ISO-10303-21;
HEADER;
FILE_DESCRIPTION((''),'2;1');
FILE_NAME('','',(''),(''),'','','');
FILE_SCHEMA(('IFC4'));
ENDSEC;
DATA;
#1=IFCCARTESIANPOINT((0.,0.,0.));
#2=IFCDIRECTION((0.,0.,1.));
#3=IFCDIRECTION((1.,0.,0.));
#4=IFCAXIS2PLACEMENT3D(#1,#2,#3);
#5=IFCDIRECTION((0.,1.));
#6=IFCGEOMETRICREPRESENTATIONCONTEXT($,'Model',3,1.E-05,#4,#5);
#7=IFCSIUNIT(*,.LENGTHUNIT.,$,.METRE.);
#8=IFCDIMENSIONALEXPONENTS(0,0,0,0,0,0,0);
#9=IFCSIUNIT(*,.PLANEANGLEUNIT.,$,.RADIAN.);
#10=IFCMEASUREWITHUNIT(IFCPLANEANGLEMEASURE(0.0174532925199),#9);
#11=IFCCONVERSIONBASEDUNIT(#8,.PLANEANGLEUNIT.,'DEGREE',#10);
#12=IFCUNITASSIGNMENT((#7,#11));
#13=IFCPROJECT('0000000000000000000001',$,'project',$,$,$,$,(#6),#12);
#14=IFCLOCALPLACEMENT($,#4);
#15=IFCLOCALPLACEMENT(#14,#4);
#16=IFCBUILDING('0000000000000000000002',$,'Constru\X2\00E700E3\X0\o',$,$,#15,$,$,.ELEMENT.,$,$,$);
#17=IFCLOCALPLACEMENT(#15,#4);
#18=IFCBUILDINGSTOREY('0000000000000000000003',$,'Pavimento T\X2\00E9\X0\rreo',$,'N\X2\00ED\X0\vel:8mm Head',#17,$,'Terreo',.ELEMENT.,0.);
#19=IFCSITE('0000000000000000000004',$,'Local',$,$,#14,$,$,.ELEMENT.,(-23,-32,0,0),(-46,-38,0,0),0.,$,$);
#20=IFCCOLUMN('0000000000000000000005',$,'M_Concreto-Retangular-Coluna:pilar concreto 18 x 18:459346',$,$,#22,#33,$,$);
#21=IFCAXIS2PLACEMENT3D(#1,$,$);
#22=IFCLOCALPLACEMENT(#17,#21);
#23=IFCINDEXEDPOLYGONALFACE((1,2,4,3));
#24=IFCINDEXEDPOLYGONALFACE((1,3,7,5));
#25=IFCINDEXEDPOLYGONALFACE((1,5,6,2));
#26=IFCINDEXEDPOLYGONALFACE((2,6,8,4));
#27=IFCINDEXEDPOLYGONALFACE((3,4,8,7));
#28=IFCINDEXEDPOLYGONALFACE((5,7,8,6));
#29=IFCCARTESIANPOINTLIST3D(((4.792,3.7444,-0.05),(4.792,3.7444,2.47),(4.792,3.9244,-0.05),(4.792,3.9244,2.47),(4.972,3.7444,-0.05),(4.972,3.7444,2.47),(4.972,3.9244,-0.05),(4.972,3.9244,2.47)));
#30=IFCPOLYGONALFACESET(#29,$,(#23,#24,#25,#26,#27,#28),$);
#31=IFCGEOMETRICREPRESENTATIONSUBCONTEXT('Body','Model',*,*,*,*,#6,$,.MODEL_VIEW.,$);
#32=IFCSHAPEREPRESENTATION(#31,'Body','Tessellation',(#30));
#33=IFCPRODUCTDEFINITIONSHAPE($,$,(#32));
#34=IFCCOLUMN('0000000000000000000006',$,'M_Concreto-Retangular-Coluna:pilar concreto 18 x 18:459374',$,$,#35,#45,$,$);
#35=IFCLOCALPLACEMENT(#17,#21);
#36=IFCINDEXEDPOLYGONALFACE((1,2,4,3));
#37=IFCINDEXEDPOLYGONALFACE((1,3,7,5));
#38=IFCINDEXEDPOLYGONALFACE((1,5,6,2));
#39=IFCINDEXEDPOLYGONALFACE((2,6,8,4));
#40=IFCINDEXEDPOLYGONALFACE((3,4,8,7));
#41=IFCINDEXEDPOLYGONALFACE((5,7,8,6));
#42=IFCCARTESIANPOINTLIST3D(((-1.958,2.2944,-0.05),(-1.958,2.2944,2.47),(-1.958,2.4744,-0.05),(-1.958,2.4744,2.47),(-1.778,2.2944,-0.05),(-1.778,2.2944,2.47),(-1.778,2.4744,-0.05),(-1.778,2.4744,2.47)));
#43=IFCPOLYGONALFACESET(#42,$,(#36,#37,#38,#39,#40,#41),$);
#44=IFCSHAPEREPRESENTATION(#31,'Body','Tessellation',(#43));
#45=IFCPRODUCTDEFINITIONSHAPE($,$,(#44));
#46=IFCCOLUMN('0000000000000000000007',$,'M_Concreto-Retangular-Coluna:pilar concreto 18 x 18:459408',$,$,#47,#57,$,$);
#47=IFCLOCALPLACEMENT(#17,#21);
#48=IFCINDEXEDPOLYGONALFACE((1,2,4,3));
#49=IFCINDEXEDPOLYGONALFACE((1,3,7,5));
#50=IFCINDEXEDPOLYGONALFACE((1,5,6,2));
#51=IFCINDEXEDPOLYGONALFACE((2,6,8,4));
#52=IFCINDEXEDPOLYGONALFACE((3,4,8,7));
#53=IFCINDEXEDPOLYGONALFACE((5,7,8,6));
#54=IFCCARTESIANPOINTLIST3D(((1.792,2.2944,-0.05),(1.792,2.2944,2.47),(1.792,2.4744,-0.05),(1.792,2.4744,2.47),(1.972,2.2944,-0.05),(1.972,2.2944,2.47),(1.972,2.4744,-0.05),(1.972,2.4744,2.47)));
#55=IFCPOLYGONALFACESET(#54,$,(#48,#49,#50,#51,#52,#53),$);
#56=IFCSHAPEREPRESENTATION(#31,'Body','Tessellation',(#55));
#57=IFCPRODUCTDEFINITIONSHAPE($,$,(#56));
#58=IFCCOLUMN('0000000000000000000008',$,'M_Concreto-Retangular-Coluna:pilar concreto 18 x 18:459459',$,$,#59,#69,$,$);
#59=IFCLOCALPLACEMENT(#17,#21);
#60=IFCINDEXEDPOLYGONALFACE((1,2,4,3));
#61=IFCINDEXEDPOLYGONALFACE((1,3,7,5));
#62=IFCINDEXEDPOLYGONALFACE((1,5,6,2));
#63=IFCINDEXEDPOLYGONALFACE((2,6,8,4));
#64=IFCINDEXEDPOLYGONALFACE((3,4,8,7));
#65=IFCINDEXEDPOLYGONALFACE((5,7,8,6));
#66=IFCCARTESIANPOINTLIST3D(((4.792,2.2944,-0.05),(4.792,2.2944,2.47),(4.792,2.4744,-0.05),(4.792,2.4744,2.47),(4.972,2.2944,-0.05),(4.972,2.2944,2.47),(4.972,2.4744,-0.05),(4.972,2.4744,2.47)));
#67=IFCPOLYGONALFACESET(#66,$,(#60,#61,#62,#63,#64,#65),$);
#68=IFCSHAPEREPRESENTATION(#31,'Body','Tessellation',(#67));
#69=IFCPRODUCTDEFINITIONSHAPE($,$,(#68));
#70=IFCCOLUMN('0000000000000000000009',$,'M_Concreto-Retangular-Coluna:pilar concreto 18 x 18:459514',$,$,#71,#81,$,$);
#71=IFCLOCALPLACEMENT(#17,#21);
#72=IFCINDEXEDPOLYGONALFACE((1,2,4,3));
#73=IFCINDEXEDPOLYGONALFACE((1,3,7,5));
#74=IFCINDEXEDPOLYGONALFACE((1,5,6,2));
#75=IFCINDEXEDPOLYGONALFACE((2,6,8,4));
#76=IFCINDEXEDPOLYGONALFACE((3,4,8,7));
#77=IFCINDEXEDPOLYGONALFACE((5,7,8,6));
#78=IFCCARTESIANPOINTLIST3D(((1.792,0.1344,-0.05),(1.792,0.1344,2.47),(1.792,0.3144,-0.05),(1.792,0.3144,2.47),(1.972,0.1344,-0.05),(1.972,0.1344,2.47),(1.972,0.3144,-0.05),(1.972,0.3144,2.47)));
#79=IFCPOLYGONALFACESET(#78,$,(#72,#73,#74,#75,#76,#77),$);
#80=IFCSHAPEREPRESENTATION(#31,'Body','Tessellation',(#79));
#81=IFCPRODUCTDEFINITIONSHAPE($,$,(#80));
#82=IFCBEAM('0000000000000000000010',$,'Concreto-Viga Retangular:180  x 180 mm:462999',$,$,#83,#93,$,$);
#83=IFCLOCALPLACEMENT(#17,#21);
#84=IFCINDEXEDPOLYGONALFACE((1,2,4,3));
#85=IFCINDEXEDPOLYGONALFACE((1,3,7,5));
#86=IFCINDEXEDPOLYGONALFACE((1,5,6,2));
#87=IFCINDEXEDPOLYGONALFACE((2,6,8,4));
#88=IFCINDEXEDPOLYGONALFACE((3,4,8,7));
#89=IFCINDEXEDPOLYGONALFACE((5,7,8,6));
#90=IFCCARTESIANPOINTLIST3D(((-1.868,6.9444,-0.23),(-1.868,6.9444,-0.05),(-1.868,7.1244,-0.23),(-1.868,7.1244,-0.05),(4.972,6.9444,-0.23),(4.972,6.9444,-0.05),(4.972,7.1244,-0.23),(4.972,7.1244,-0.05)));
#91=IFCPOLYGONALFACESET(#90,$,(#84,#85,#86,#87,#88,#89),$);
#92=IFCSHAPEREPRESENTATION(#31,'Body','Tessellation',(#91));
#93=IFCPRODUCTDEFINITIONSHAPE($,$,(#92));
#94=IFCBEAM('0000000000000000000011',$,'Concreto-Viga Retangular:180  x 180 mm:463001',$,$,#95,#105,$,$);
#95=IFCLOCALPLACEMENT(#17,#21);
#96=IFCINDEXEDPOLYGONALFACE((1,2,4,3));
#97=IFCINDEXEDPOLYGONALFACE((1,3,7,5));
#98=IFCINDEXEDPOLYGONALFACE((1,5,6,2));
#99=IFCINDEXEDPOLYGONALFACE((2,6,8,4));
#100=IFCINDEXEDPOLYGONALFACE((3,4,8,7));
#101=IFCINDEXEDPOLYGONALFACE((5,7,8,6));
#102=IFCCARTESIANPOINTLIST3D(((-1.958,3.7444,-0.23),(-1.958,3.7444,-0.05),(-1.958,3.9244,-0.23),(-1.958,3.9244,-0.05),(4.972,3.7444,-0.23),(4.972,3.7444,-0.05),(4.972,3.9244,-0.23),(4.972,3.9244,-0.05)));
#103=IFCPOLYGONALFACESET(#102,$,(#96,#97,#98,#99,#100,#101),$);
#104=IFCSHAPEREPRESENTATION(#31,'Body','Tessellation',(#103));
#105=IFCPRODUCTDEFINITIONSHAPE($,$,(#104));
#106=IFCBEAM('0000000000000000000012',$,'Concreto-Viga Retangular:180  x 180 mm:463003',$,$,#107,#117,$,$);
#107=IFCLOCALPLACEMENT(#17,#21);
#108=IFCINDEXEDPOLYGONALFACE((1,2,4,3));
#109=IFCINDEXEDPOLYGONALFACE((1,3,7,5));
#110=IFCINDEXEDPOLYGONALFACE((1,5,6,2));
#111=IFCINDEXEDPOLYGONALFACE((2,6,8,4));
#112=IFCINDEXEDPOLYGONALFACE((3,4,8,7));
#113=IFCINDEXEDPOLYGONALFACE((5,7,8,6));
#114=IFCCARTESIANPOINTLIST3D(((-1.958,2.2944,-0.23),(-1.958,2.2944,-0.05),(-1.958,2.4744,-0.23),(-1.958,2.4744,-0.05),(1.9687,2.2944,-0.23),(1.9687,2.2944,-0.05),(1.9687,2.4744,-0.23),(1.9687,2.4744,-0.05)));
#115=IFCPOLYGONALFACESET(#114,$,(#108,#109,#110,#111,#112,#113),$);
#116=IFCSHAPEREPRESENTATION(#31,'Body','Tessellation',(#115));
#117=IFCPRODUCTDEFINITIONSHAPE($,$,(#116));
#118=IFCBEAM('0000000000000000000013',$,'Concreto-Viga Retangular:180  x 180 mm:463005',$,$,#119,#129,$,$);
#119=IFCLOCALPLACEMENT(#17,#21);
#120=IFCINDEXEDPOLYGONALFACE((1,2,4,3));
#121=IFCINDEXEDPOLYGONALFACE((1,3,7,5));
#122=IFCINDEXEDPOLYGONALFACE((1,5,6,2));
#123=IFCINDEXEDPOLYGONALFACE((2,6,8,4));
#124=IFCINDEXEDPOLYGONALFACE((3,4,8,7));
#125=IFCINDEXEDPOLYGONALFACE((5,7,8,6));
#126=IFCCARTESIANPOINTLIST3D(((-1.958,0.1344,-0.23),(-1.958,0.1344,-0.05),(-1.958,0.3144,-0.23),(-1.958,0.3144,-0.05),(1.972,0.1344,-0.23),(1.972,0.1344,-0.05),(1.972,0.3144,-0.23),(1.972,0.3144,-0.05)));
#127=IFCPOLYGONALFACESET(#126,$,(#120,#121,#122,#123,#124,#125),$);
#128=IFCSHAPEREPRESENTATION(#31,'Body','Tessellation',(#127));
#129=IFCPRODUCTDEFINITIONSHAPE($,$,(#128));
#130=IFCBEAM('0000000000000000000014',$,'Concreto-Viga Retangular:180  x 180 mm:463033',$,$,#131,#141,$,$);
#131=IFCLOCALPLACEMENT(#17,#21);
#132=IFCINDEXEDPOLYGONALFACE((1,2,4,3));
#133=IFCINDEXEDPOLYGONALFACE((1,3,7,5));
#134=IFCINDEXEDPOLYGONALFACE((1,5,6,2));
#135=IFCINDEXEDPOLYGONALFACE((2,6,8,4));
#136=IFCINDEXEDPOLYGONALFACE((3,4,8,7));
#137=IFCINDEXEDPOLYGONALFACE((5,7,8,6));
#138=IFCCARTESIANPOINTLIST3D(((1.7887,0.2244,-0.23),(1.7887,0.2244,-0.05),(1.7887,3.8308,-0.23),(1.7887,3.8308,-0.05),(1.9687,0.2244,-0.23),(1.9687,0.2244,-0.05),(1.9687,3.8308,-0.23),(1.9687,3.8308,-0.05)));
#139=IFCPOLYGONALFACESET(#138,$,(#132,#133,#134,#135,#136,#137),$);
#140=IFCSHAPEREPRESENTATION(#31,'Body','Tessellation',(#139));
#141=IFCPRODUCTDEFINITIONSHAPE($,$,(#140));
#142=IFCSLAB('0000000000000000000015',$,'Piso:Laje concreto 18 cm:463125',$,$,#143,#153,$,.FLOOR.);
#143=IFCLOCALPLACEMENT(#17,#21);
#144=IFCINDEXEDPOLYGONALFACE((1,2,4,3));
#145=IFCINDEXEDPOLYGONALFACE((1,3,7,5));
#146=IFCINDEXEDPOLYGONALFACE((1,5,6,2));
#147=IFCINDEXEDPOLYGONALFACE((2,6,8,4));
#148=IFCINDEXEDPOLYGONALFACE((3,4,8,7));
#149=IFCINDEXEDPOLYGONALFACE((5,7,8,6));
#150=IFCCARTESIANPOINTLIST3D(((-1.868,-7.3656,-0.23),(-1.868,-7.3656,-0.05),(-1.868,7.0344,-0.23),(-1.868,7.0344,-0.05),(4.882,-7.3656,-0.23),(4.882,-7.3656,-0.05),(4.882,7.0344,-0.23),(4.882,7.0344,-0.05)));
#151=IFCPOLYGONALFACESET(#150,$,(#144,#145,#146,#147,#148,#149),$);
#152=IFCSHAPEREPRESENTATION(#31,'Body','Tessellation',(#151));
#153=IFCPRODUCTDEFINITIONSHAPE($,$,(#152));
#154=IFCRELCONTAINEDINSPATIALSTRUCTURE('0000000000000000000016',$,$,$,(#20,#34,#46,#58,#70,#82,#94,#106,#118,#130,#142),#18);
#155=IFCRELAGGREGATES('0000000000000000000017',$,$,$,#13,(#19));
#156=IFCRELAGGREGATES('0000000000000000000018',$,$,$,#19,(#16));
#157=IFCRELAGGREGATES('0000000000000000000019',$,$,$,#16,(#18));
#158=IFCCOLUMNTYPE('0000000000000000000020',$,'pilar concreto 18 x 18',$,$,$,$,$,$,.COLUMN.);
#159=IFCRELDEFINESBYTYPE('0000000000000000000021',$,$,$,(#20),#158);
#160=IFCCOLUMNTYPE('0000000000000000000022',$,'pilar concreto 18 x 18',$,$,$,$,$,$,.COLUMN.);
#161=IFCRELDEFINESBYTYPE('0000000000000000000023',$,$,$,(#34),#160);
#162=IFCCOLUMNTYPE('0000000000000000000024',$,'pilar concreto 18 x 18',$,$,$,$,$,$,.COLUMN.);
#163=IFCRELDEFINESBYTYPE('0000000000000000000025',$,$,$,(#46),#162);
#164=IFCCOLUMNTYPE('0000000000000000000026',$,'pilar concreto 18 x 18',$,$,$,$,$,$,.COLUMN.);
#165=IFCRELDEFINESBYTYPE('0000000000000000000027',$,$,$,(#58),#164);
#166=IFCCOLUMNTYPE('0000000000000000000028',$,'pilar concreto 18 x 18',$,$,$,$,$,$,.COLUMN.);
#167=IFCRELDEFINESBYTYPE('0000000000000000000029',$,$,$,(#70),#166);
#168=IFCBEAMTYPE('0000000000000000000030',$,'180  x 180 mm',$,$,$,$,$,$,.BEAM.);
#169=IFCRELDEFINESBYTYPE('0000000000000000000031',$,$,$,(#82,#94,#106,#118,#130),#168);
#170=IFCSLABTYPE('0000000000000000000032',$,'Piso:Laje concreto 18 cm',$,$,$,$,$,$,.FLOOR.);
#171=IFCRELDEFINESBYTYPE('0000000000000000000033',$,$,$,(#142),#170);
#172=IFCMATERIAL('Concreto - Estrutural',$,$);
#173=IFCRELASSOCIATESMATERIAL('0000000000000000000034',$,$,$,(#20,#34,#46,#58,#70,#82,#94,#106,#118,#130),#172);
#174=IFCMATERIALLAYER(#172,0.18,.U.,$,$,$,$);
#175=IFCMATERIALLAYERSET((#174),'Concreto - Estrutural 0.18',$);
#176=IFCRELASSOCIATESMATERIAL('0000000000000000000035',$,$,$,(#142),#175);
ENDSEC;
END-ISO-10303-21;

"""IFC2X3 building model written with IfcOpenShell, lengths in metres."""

from ifc_helpers import new_model, entity, si_unit, converted_unit, direction, frame, frame_2d, origin_with_axes, origin_2d_with_axis, place, context, subcontext, project, spatial, polyline, rectangle, outline, extrude, material, layer, layer_set, layer_usage, type_object, element, save


model = new_model("IFC2X3")

# Units and contexts
model_context = context("Model", 3, precision=1e-05, world=origin_with_axes(), true_north=direction((0.0, 1.0)))
body_context = subcontext(model_context, "Body", "Model", "MODEL_VIEW")
ifc_project = project(units=[si_unit("LENGTHUNIT", "METRE"), converted_unit("PLANEANGLEUNIT", "DEGREE", entity("IfcPlaneAngleMeasure", 0.0174532925199), si_unit("PLANEANGLEUNIT", "RADIAN"), dimensions=[0, 0, 0, 0, 0, 0, 0])], contexts=[model_context])

# Site, building, storey
site_placement = place(None, origin_with_axes())
site = spatial("IfcSite", under=ifc_project, at=site_placement, Name="Local", CompositionType="ELEMENT", RefLatitude=(-23, -32, 0, 0), RefLongitude=(-46, -38, 0, 0), RefElevation=0.0)
building_placement = place(site_placement, origin_with_axes())
building = spatial("IfcBuilding", under=site, at=building_placement, Name="Construção", CompositionType="ELEMENT")
storey_placement = place(building_placement, origin_with_axes())
storey = spatial("IfcBuildingStorey", under=building, at=storey_placement, Name="Pavimento Térreo", ObjectType="Nível:8mm Head", LongName="Terreo", CompositionType="ELEMENT", Elevation=0.0)

# Shared definitions
ifc_material = material(Name="Concreto - Estrutural")

# Columns
column_type_1 = type_object("IfcColumnType", Name="pilar concreto 18 x 18", PredefinedType="COLUMN")
column_1_placement = place(storey_placement, frame((4.882, 3.8344, -0.05), z_axis=(0.0, 0.0, 1.0), x_axis=(0.0, -1.0, 0.0)))
element("IfcColumn", 1, at=column_1_placement, inside=storey, type_object=column_type_1, material=ifc_material, Name="M_Concreto-Retangular-Coluna:pilar concreto 18 x 18:459346", context=body_context, shape_type="SweptSolid", body=[
    extrude(rectangle(XDim=0.18, YDim=0.18, at=origin_2d_with_axis()), origin_with_axes(), (0.0, 0.0, 1.0), 2.52),
])
column_type_2 = type_object("IfcColumnType", Name="pilar concreto 18 x 18", PredefinedType="COLUMN")
column_2_placement = place(storey_placement, frame((-1.868, 2.3844, -0.05), z_axis=(0.0, 0.0, 1.0), x_axis=(0.0, -1.0, 0.0)))
element("IfcColumn", 2, at=column_2_placement, inside=storey, type_object=column_type_2, material=ifc_material, Name="M_Concreto-Retangular-Coluna:pilar concreto 18 x 18:459374", context=body_context, shape_type="SweptSolid", body=[
    extrude(rectangle(XDim=0.18, YDim=0.18, at=origin_2d_with_axis()), origin_with_axes(), (0.0, 0.0, 1.0), 2.52),
])
column_type_3 = type_object("IfcColumnType", Name="pilar concreto 18 x 18", PredefinedType="COLUMN")
column_3_placement = place(storey_placement, frame((1.882, 2.3844, -0.05), z_axis=(0.0, 0.0, 1.0), x_axis=(0.0, -1.0, 0.0)))
element("IfcColumn", 3, at=column_3_placement, inside=storey, type_object=column_type_3, material=ifc_material, Name="M_Concreto-Retangular-Coluna:pilar concreto 18 x 18:459408", context=body_context, shape_type="SweptSolid", body=[
    extrude(rectangle(XDim=0.18, YDim=0.18, at=origin_2d_with_axis()), origin_with_axes(), (0.0, 0.0, 1.0), 2.52),
])
column_type_4 = type_object("IfcColumnType", Name="pilar concreto 18 x 18", PredefinedType="COLUMN")
column_4_placement = place(storey_placement, frame((4.882, 2.3844, -0.05), z_axis=(0.0, 0.0, 1.0), x_axis=(0.0, -1.0, 0.0)))
element("IfcColumn", 4, at=column_4_placement, inside=storey, type_object=column_type_4, material=ifc_material, Name="M_Concreto-Retangular-Coluna:pilar concreto 18 x 18:459459", context=body_context, shape_type="SweptSolid", body=[
    extrude(rectangle(XDim=0.18, YDim=0.18, at=origin_2d_with_axis()), origin_with_axes(), (0.0, 0.0, 1.0), 2.52),
])
column_type_5 = type_object("IfcColumnType", Name="pilar concreto 18 x 18", PredefinedType="COLUMN")
column_5_placement = place(storey_placement, frame((1.882, 0.2244, -0.05), z_axis=(0.0, 0.0, 1.0), x_axis=(0.0, -1.0, 0.0)))
element("IfcColumn", 5, at=column_5_placement, inside=storey, type_object=column_type_5, material=ifc_material, Name="M_Concreto-Retangular-Coluna:pilar concreto 18 x 18:459514", context=body_context, shape_type="SweptSolid", body=[
    extrude(rectangle(XDim=0.18, YDim=0.18, at=origin_2d_with_axis()), origin_with_axes(), (0.0, 0.0, 1.0), 2.52),
])

# Beams
beam_type = type_object("IfcBeamType", Name="180  x 180 mm", PredefinedType="BEAM")
beam_1_placement = place(storey_placement, frame((4.972, 7.0344, -0.05), z_axis=(0.0, 0.0, 1.0), x_axis=(0.0, 1.0, 0.0)))
element("IfcBeam", 6, at=beam_1_placement, inside=storey, type_object=beam_type, material=ifc_material, Name="Concreto-Viga Retangular:180  x 180 mm:462999", context=body_context, shape_type="SweptSolid", body=[
    extrude(rectangle(XDim=0.18, YDim=0.18, at=frame_2d((-0.09, 0.0), x_axis=(1.0, 0.0))), frame((0.0, 0.0, 0.0), z_axis=(0.0, 1.0, 0.0), x_axis=(0.0, 0.0, 1.0)), (0.0, 0.0, 1.0), 6.84),
])
beam_2_placement = place(storey_placement, frame((4.972, 3.8344, -0.05), z_axis=(0.0, 0.0, 1.0), x_axis=(0.0, 1.0, 0.0)))
element("IfcBeam", 7, at=beam_2_placement, inside=storey, type_object=beam_type, material=ifc_material, Name="Concreto-Viga Retangular:180  x 180 mm:463001", context=body_context, shape_type="SweptSolid", body=[
    extrude(rectangle(XDim=0.18, YDim=0.18, at=frame_2d((-0.09, 0.0), x_axis=(1.0, 0.0))), frame((0.0, 0.0, 0.0), z_axis=(0.0, 1.0, 0.0), x_axis=(0.0, 0.0, 1.0)), (0.0, 0.0, 1.0), 6.93),
])
beam_3_placement = place(storey_placement, frame((1.9687, 2.3844, -0.05), z_axis=(0.0, 0.0, 1.0), x_axis=(0.0, 1.0, 0.0)))
element("IfcBeam", 8, at=beam_3_placement, inside=storey, type_object=beam_type, material=ifc_material, Name="Concreto-Viga Retangular:180  x 180 mm:463003", context=body_context, shape_type="SweptSolid", body=[
    extrude(rectangle(XDim=0.18, YDim=0.18, at=frame_2d((-0.09, 0.0), x_axis=(1.0, 0.0))), frame((0.0, 0.0, 0.0), z_axis=(0.0, 1.0, 0.0), x_axis=(0.0, 0.0, 1.0)), (0.0, 0.0, 1.0), 3.9267),
])
beam_4_placement = place(storey_placement, frame((1.972, 0.2244, -0.05), z_axis=(0.0, 0.0, 1.0), x_axis=(0.0, 1.0, 0.0)))
element("IfcBeam", 9, at=beam_4_placement, inside=storey, type_object=beam_type, material=ifc_material, Name="Concreto-Viga Retangular:180  x 180 mm:463005", context=body_context, shape_type="SweptSolid", body=[
    extrude(rectangle(XDim=0.18, YDim=0.18, at=frame_2d((-0.09, 0.0), x_axis=(1.0, 0.0))), frame((0.0, 0.0, 0.0), z_axis=(0.0, 1.0, 0.0), x_axis=(0.0, 0.0, 1.0)), (0.0, 0.0, 1.0), 3.93),
])
beam_5_placement = place(storey_placement, frame((1.8787, 0.2244, -0.05), z_axis=(0.0, 0.0, 1.0), x_axis=(1.0, 0.0, 0.0)))
element("IfcBeam", 10, at=beam_5_placement, inside=storey, type_object=beam_type, material=ifc_material, Name="Concreto-Viga Retangular:180  x 180 mm:463033", context=body_context, shape_type="SweptSolid", body=[
    extrude(rectangle(XDim=0.18, YDim=0.18, at=frame_2d((-0.09, 0.0), x_axis=(1.0, 0.0))), frame((0.0, 0.0, 0.0), z_axis=(0.0, 1.0, 0.0), x_axis=(0.0, 0.0, 1.0)), (0.0, 0.0, 1.0), 3.6063),
])

# Slab
ifc_layer = layer(ifc_material, 0.18, ventilated="UNKNOWN")
ifc_layer_set = layer_set([ifc_layer], Name="Concreto - Estrutural 0.18")
ifc_layer_usage = layer_usage(ifc_layer_set, "AXIS3", "NEGATIVE", 0.18)
slab_type = type_object("IfcSlabType", Name="Piso:Laje concreto 18 cm", PredefinedType="FLOOR")
slab_placement = place(storey_placement, frame((-1.868, 7.0344, -0.05), z_axis=(0.0, 0.0, 1.0), x_axis=(1.0, 0.0, 0.0)))
element("IfcSlab", 11, at=slab_placement, inside=storey, type_object=slab_type, material=ifc_layer_usage, Name="Piso:Laje concreto 18 cm:463125", PredefinedType="FLOOR", context=body_context, shape_type="SweptSolid", body=[
    extrude(outline(polyline([(0.0, 0.0), (0.0, -14.4), (6.75, -14.4), (6.75, 0.0), (0.0, 0.0)])), frame((0.0, 0.0, -0.18), z_axis=(0.0, 0.0, 1.0), x_axis=(1.0, 0.0, 0.0)), (0.0, 0.0, 1.0), 0.18),
])

save(model, "model.ifc")
